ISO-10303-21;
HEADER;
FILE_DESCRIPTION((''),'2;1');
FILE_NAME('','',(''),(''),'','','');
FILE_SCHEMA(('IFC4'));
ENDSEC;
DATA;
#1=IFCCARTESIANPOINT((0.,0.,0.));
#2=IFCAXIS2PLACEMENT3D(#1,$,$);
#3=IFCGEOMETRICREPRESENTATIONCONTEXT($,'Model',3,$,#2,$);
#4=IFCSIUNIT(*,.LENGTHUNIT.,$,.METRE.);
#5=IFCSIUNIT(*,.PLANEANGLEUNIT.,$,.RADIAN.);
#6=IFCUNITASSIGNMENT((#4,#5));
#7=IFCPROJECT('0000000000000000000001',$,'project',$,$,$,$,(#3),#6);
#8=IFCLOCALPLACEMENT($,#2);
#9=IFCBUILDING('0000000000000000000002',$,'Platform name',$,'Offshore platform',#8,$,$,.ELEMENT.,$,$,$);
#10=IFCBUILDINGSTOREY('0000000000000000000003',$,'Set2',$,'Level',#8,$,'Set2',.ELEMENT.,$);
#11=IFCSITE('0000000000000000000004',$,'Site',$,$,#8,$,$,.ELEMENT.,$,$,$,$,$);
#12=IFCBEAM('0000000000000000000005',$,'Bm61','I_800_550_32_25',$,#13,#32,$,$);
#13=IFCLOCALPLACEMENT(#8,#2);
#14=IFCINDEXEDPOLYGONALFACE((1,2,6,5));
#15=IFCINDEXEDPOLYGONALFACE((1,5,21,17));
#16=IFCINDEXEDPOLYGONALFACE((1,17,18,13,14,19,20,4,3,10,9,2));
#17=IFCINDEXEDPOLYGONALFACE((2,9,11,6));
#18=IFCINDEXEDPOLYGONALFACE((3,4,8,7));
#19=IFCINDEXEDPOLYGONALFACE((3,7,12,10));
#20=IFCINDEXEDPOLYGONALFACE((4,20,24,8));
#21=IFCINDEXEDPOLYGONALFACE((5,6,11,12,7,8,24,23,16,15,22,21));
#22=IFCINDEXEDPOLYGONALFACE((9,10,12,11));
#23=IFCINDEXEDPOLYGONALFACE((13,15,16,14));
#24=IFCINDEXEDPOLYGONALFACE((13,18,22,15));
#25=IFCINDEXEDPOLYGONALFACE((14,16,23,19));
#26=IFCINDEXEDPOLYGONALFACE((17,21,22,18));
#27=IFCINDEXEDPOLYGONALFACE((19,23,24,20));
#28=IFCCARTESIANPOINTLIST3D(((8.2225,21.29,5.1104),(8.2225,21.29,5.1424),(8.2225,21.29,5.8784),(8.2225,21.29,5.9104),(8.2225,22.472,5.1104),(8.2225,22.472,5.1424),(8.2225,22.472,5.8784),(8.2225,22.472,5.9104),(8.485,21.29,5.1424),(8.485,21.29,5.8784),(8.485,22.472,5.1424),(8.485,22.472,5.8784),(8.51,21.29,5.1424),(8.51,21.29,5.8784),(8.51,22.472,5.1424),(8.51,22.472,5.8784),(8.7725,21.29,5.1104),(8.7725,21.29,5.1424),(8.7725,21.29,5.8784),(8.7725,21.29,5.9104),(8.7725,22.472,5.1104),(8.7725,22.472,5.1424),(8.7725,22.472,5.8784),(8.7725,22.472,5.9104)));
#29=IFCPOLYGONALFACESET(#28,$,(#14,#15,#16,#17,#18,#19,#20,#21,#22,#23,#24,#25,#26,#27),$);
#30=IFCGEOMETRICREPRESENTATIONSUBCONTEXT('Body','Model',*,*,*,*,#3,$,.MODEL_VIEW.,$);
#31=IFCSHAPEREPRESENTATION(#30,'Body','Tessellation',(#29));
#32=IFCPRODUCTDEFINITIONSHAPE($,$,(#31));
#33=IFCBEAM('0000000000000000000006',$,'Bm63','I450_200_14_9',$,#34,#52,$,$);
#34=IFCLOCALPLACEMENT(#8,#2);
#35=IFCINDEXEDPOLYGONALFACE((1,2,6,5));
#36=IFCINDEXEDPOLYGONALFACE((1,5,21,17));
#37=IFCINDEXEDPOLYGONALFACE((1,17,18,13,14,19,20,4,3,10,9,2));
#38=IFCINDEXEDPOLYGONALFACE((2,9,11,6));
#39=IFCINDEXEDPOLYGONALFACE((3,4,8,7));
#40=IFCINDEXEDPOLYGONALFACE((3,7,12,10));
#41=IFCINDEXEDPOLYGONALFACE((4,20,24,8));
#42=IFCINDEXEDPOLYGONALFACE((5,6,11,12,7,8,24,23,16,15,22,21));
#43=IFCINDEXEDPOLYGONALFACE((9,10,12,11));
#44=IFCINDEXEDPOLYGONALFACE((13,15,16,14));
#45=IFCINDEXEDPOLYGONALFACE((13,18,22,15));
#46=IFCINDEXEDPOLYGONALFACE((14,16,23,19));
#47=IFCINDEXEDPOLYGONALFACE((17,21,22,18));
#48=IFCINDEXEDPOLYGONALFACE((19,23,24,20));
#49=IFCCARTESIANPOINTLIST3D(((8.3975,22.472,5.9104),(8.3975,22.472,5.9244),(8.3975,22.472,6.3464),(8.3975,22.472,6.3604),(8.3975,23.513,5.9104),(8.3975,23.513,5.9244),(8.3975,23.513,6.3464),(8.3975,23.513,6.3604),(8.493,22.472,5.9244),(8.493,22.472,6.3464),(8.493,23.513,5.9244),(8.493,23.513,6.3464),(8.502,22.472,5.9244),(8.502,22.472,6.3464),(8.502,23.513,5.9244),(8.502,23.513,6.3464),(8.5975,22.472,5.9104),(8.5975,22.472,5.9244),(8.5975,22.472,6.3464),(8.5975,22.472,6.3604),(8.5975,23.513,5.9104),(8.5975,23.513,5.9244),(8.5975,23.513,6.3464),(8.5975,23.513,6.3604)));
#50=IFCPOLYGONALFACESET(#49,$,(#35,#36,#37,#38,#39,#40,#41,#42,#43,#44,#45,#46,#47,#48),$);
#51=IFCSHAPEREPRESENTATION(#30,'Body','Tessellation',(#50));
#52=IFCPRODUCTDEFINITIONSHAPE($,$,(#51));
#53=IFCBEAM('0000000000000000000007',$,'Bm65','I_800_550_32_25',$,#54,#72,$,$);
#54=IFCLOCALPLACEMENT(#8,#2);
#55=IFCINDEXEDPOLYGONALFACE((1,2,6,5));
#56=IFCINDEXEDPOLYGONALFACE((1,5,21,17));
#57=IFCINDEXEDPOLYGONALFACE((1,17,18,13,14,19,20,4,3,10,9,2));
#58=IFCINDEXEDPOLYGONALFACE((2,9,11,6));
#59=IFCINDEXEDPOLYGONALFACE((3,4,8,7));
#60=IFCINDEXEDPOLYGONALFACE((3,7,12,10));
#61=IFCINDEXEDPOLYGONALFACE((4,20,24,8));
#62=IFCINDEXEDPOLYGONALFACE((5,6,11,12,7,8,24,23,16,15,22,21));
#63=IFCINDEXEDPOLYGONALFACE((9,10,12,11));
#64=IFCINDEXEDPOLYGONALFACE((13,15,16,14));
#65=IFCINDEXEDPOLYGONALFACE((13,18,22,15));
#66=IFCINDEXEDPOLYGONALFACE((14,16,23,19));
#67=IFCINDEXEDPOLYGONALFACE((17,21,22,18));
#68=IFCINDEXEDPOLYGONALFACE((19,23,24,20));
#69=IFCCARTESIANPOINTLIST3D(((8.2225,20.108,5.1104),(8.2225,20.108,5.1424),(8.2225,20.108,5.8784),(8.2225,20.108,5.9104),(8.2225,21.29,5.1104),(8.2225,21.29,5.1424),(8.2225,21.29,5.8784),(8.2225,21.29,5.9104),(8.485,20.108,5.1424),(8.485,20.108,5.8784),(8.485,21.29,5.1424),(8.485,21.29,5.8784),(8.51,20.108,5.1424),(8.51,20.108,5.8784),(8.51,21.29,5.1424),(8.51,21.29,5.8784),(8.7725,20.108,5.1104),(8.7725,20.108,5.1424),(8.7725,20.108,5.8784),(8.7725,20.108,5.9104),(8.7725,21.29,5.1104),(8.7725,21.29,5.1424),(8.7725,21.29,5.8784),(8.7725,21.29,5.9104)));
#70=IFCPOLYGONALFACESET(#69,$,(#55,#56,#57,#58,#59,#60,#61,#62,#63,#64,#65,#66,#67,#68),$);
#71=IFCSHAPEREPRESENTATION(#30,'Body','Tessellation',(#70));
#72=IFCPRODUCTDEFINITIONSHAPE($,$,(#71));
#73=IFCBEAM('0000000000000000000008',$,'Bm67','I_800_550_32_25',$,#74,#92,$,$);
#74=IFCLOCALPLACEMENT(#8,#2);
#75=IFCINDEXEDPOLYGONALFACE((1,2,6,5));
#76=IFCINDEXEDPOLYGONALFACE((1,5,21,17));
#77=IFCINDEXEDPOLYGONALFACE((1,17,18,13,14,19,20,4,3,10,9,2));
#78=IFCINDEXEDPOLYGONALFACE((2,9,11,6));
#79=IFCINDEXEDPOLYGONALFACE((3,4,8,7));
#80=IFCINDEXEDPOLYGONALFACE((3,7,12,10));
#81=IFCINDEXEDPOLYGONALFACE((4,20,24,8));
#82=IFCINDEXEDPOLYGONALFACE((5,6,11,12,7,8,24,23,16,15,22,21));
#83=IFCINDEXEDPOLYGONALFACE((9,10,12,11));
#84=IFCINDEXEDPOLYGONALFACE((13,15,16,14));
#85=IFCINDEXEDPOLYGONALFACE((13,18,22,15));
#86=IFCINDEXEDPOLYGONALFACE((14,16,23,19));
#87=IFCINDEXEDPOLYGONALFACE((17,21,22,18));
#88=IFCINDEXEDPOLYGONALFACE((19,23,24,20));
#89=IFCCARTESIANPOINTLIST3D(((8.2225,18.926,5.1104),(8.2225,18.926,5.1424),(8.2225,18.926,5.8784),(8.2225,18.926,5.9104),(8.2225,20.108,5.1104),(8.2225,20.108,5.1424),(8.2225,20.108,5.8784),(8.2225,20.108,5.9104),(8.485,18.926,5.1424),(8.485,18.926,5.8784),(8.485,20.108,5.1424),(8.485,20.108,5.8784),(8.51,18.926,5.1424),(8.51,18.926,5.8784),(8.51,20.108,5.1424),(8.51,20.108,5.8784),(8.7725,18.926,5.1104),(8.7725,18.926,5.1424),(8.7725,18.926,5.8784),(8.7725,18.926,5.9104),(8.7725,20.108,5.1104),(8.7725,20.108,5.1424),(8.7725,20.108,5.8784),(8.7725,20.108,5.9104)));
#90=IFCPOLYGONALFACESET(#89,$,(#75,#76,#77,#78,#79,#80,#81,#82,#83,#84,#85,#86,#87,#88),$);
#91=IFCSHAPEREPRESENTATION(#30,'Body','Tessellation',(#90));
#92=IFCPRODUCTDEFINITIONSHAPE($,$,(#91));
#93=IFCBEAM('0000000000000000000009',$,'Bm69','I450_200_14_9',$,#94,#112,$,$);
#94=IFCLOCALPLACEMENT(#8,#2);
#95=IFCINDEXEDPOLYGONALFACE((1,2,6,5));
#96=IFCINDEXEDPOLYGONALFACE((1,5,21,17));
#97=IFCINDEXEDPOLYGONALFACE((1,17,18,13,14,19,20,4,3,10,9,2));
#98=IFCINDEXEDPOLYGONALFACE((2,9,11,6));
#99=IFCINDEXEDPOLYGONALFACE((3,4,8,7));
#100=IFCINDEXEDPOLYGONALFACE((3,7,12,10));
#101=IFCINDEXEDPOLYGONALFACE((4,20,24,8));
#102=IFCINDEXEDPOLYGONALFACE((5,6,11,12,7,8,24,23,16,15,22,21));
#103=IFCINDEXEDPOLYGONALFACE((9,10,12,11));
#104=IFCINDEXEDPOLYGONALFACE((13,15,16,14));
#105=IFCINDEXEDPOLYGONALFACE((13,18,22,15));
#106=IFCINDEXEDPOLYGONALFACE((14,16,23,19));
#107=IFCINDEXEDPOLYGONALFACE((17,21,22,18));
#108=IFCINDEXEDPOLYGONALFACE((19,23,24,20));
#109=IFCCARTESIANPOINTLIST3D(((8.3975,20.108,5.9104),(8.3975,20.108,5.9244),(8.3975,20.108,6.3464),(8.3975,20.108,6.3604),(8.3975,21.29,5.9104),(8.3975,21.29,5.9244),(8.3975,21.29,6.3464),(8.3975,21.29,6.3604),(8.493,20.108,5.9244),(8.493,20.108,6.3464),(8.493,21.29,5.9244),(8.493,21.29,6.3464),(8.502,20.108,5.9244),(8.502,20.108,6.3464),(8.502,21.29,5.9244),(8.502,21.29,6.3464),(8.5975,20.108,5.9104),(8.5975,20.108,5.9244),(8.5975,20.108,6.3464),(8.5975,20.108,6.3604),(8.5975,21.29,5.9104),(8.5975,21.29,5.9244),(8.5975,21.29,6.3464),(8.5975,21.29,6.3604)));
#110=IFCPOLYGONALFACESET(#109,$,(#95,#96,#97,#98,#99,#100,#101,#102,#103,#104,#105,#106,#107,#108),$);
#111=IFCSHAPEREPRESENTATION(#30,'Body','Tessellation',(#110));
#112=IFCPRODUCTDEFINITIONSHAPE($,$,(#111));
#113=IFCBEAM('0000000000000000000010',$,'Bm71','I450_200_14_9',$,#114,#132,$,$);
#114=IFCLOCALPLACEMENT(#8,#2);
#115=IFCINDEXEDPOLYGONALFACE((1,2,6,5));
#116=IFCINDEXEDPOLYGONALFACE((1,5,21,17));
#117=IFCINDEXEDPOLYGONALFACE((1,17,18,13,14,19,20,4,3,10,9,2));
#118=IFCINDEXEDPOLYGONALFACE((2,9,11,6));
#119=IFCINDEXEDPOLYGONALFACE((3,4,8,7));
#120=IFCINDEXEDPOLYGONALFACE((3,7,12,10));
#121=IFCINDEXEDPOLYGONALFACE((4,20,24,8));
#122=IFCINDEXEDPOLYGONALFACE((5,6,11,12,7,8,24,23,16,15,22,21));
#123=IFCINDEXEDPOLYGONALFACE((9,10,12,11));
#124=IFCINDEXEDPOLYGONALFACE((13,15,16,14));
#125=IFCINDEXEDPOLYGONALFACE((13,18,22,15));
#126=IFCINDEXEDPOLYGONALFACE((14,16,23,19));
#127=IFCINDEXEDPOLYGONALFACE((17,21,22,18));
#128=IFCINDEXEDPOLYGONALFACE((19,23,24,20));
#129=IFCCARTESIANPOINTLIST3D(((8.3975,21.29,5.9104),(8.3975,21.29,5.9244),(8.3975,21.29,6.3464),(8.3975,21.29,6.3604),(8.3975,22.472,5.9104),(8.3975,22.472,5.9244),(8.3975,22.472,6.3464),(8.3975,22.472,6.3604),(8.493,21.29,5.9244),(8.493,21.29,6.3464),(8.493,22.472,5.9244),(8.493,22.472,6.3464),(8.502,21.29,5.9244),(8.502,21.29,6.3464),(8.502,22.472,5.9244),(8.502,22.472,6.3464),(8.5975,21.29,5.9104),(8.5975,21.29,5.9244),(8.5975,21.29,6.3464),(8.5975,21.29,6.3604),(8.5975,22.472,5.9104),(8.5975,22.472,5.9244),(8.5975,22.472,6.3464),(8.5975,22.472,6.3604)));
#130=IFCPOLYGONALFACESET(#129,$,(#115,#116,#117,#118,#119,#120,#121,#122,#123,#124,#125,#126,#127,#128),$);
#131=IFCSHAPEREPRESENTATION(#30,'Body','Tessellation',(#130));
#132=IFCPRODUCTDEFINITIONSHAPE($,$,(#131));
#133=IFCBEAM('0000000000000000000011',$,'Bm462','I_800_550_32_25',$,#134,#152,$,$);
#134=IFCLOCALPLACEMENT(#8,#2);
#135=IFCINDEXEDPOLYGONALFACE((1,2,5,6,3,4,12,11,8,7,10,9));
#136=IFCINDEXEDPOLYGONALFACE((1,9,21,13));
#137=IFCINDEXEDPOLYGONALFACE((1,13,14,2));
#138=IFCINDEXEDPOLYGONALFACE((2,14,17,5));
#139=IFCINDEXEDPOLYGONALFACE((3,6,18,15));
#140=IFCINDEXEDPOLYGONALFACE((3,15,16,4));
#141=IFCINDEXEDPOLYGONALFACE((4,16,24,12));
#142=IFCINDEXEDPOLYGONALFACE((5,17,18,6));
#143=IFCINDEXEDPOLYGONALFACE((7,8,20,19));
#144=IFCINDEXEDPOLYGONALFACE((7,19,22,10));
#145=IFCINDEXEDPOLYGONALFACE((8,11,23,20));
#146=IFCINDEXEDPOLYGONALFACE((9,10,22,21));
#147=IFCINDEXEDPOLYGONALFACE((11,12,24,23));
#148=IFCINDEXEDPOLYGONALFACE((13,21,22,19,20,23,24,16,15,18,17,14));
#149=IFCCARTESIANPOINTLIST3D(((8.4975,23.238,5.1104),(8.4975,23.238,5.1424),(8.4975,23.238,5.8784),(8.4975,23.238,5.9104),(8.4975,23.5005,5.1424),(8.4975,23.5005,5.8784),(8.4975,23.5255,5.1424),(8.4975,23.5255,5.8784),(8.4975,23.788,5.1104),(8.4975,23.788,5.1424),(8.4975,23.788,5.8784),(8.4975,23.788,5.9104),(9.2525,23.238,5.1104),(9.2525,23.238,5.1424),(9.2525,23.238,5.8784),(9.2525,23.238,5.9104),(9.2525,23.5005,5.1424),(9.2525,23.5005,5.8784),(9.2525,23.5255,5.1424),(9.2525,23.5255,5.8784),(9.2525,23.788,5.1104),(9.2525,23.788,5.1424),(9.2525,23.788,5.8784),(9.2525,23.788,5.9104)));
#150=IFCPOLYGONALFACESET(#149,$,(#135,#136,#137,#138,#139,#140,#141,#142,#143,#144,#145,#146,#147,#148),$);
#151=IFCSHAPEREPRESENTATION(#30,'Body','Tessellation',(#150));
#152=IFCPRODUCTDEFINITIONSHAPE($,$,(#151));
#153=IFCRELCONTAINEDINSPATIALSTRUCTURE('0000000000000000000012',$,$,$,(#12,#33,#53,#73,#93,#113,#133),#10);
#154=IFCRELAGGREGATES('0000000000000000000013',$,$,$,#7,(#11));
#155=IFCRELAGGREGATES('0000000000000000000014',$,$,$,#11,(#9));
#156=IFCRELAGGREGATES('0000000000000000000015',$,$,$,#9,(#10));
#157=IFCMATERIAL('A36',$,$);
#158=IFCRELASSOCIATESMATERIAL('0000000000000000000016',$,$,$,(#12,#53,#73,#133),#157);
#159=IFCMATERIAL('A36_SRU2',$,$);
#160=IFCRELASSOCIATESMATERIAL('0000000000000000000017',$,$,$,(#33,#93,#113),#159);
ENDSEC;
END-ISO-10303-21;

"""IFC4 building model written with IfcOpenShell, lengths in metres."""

from ifc_helpers import new_model, si_unit, frame, origin, origin_2d, place, context, subcontext, project, spatial, i_section, extrude, source, transform, mapped, material, element, save


model = new_model("IFC4")

# Units and contexts
model_context = context("Model", 3, world=origin())
body_context = subcontext(model_context, "Body", "Model", "MODEL_VIEW")
ifc_project = project(units=[si_unit("LENGTHUNIT", "METRE"), si_unit("PLANEANGLEUNIT", "RADIAN")], contexts=[model_context])

# Site, building, storey
placement_1 = place(None, origin())
site = spatial("IfcSite", under=ifc_project, at=placement_1, Name="Site", CompositionType="ELEMENT")
building = spatial("IfcBuilding", under=site, at=placement_1, Name="Platform name", ObjectType="Offshore platform", CompositionType="ELEMENT")
storey = spatial("IfcBuildingStorey", under=building, at=placement_1, Name="Set2", ObjectType="Level", LongName="Set2", CompositionType="ELEMENT")

# Beams
ifc_material_1 = material(Name="A36_SRU2")
ifc_material_2 = material(Name="A36")
shared_shape_1 = source(origin(), body_context, "Body", "SweptSolid", [
    extrude(i_section(OverallWidth=0.55, OverallDepth=0.8, WebThickness=0.025, FlangeThickness=0.032, FilletRadius=0.0, at=origin_2d()), frame((0.0, 0.0, 0.0), z_axis=(0.0, -1.0, 0.0), x_axis=(1.0, 0.0, 0.0)), (0.0, 0.0, 1.0), 1.182),
])
placement_2 = place(None, origin())
placement_3 = place(placement_2, origin())
placement_4 = place(placement_3, origin())
beam_1_placement = place(placement_4, frame((8.4975, 22.472, 5.5104)))
element("IfcBeam", 1, at=beam_1_placement, inside=storey, material=ifc_material_2, Name="Bm61", Description="I_800_550_32_25", context=body_context, shape_type="MappedRepresentation", body=[
    mapped(shared_shape_1, transform((0.0, 0.0, 0.0), scale=1.0)),
])
shared_shape_2 = source(origin(), body_context, "Body", "SweptSolid", [
    extrude(i_section(OverallWidth=0.2, OverallDepth=0.45, WebThickness=0.009, FlangeThickness=0.014, FilletRadius=0.0, at=origin_2d()), frame((0.0, 0.0, 0.0), z_axis=(0.0, 1.0, 0.0), x_axis=(-1.0, 0.0, 0.0)), (0.0, 0.0, 1.0), 1.041),
])
placement_5 = place(None, origin())
placement_6 = place(placement_5, origin())
placement_7 = place(placement_6, origin())
beam_2_placement = place(placement_7, frame((8.4975, 22.472, 6.1354)))
element("IfcBeam", 2, at=beam_2_placement, inside=storey, material=ifc_material_1, Name="Bm63", Description="I450_200_14_9", context=body_context, shape_type="MappedRepresentation", body=[
    mapped(shared_shape_2, transform((0.0, 0.0, 0.0), scale=1.0)),
])
shared_shape_3 = source(origin(), body_context, "Body", "SweptSolid", [
    extrude(i_section(OverallWidth=0.55, OverallDepth=0.8, WebThickness=0.025, FlangeThickness=0.032, FilletRadius=0.0, at=origin_2d()), frame((0.0, 0.0, 0.0), z_axis=(0.0, -1.0, 0.0), x_axis=(1.0, 0.0, 0.0)), (0.0, 0.0, 1.0), 1.182),
])
placement_8 = place(None, origin())
placement_9 = place(placement_8, origin())
placement_10 = place(placement_9, origin())
beam_3_placement = place(placement_10, frame((8.4975, 21.29, 5.5104)))
element("IfcBeam", 3, at=beam_3_placement, inside=storey, material=ifc_material_2, Name="Bm65", Description="I_800_550_32_25", context=body_context, shape_type="MappedRepresentation", body=[
    mapped(shared_shape_3, transform((0.0, 0.0, 0.0), scale=1.0)),
])
shared_shape_4 = source(origin(), body_context, "Body", "SweptSolid", [
    extrude(i_section(OverallWidth=0.55, OverallDepth=0.8, WebThickness=0.025, FlangeThickness=0.032, FilletRadius=0.0, at=origin_2d()), frame((0.0, 0.0, 0.0), z_axis=(0.0, -1.0, 0.0), x_axis=(1.0, 0.0, 0.0)), (0.0, 0.0, 1.0), 1.182),
])
placement_11 = place(None, origin())
placement_12 = place(placement_11, origin())
placement_13 = place(placement_12, origin())
beam_4_placement = place(placement_13, frame((8.4975, 20.108, 5.5104)))
element("IfcBeam", 4, at=beam_4_placement, inside=storey, material=ifc_material_2, Name="Bm67", Description="I_800_550_32_25", context=body_context, shape_type="MappedRepresentation", body=[
    mapped(shared_shape_4, transform((0.0, 0.0, 0.0), scale=1.0)),
])
shared_shape_5 = source(origin(), body_context, "Body", "SweptSolid", [
    extrude(i_section(OverallWidth=0.2, OverallDepth=0.45, WebThickness=0.009, FlangeThickness=0.014, FilletRadius=0.0, at=origin_2d()), frame((0.0, 0.0, 0.0), z_axis=(0.0, 1.0, 0.0), x_axis=(-1.0, 0.0, 0.0)), (0.0, 0.0, 1.0), 1.182),
])
placement_14 = place(None, origin())
placement_15 = place(placement_14, origin())
placement_16 = place(placement_15, origin())
beam_5_placement = place(placement_16, frame((8.4975, 20.108, 6.1354)))
element("IfcBeam", 5, at=beam_5_placement, inside=storey, material=ifc_material_1, Name="Bm69", Description="I450_200_14_9", context=body_context, shape_type="MappedRepresentation", body=[
    mapped(shared_shape_5, transform((0.0, 0.0, 0.0), scale=1.0)),
])
shared_shape_6 = source(origin(), body_context, "Body", "SweptSolid", [
    extrude(i_section(OverallWidth=0.2, OverallDepth=0.45, WebThickness=0.009, FlangeThickness=0.014, FilletRadius=0.0, at=origin_2d()), frame((0.0, 0.0, 0.0), z_axis=(0.0, 1.0, 0.0), x_axis=(-1.0, 0.0, 0.0)), (0.0, 0.0, 1.0), 1.182),
])
placement_17 = place(None, origin())
placement_18 = place(placement_17, origin())
placement_19 = place(placement_18, origin())
beam_6_placement = place(placement_19, frame((8.4975, 21.29, 6.1354)))
element("IfcBeam", 6, at=beam_6_placement, inside=storey, material=ifc_material_1, Name="Bm71", Description="I450_200_14_9", context=body_context, shape_type="MappedRepresentation", body=[
    mapped(shared_shape_6, transform((0.0, 0.0, 0.0), scale=1.0)),
])
shared_shape_7 = source(origin(), body_context, "Body", "SweptSolid", [
    extrude(i_section(OverallWidth=0.55, OverallDepth=0.8, WebThickness=0.025, FlangeThickness=0.032, FilletRadius=0.0, at=origin_2d()), frame((0.0, 0.0, 0.0), z_axis=(1.0, 0.0, 0.0), x_axis=(0.0, 1.0, 0.0)), (0.0, 0.0, 1.0), 0.755),
])
placement_20 = place(None, origin())
placement_21 = place(placement_20, origin())
placement_22 = place(placement_21, origin())
beam_7_placement = place(placement_22, frame((8.4975, 23.513, 5.5104)))
element("IfcBeam", 7, at=beam_7_placement, inside=storey, material=ifc_material_2, Name="Bm462", Description="I_800_550_32_25", context=body_context, shape_type="MappedRepresentation", body=[
    mapped(shared_shape_7, transform((0.0, 0.0, 0.0), scale=1.0)),
])

save(model, "model.ifc")
